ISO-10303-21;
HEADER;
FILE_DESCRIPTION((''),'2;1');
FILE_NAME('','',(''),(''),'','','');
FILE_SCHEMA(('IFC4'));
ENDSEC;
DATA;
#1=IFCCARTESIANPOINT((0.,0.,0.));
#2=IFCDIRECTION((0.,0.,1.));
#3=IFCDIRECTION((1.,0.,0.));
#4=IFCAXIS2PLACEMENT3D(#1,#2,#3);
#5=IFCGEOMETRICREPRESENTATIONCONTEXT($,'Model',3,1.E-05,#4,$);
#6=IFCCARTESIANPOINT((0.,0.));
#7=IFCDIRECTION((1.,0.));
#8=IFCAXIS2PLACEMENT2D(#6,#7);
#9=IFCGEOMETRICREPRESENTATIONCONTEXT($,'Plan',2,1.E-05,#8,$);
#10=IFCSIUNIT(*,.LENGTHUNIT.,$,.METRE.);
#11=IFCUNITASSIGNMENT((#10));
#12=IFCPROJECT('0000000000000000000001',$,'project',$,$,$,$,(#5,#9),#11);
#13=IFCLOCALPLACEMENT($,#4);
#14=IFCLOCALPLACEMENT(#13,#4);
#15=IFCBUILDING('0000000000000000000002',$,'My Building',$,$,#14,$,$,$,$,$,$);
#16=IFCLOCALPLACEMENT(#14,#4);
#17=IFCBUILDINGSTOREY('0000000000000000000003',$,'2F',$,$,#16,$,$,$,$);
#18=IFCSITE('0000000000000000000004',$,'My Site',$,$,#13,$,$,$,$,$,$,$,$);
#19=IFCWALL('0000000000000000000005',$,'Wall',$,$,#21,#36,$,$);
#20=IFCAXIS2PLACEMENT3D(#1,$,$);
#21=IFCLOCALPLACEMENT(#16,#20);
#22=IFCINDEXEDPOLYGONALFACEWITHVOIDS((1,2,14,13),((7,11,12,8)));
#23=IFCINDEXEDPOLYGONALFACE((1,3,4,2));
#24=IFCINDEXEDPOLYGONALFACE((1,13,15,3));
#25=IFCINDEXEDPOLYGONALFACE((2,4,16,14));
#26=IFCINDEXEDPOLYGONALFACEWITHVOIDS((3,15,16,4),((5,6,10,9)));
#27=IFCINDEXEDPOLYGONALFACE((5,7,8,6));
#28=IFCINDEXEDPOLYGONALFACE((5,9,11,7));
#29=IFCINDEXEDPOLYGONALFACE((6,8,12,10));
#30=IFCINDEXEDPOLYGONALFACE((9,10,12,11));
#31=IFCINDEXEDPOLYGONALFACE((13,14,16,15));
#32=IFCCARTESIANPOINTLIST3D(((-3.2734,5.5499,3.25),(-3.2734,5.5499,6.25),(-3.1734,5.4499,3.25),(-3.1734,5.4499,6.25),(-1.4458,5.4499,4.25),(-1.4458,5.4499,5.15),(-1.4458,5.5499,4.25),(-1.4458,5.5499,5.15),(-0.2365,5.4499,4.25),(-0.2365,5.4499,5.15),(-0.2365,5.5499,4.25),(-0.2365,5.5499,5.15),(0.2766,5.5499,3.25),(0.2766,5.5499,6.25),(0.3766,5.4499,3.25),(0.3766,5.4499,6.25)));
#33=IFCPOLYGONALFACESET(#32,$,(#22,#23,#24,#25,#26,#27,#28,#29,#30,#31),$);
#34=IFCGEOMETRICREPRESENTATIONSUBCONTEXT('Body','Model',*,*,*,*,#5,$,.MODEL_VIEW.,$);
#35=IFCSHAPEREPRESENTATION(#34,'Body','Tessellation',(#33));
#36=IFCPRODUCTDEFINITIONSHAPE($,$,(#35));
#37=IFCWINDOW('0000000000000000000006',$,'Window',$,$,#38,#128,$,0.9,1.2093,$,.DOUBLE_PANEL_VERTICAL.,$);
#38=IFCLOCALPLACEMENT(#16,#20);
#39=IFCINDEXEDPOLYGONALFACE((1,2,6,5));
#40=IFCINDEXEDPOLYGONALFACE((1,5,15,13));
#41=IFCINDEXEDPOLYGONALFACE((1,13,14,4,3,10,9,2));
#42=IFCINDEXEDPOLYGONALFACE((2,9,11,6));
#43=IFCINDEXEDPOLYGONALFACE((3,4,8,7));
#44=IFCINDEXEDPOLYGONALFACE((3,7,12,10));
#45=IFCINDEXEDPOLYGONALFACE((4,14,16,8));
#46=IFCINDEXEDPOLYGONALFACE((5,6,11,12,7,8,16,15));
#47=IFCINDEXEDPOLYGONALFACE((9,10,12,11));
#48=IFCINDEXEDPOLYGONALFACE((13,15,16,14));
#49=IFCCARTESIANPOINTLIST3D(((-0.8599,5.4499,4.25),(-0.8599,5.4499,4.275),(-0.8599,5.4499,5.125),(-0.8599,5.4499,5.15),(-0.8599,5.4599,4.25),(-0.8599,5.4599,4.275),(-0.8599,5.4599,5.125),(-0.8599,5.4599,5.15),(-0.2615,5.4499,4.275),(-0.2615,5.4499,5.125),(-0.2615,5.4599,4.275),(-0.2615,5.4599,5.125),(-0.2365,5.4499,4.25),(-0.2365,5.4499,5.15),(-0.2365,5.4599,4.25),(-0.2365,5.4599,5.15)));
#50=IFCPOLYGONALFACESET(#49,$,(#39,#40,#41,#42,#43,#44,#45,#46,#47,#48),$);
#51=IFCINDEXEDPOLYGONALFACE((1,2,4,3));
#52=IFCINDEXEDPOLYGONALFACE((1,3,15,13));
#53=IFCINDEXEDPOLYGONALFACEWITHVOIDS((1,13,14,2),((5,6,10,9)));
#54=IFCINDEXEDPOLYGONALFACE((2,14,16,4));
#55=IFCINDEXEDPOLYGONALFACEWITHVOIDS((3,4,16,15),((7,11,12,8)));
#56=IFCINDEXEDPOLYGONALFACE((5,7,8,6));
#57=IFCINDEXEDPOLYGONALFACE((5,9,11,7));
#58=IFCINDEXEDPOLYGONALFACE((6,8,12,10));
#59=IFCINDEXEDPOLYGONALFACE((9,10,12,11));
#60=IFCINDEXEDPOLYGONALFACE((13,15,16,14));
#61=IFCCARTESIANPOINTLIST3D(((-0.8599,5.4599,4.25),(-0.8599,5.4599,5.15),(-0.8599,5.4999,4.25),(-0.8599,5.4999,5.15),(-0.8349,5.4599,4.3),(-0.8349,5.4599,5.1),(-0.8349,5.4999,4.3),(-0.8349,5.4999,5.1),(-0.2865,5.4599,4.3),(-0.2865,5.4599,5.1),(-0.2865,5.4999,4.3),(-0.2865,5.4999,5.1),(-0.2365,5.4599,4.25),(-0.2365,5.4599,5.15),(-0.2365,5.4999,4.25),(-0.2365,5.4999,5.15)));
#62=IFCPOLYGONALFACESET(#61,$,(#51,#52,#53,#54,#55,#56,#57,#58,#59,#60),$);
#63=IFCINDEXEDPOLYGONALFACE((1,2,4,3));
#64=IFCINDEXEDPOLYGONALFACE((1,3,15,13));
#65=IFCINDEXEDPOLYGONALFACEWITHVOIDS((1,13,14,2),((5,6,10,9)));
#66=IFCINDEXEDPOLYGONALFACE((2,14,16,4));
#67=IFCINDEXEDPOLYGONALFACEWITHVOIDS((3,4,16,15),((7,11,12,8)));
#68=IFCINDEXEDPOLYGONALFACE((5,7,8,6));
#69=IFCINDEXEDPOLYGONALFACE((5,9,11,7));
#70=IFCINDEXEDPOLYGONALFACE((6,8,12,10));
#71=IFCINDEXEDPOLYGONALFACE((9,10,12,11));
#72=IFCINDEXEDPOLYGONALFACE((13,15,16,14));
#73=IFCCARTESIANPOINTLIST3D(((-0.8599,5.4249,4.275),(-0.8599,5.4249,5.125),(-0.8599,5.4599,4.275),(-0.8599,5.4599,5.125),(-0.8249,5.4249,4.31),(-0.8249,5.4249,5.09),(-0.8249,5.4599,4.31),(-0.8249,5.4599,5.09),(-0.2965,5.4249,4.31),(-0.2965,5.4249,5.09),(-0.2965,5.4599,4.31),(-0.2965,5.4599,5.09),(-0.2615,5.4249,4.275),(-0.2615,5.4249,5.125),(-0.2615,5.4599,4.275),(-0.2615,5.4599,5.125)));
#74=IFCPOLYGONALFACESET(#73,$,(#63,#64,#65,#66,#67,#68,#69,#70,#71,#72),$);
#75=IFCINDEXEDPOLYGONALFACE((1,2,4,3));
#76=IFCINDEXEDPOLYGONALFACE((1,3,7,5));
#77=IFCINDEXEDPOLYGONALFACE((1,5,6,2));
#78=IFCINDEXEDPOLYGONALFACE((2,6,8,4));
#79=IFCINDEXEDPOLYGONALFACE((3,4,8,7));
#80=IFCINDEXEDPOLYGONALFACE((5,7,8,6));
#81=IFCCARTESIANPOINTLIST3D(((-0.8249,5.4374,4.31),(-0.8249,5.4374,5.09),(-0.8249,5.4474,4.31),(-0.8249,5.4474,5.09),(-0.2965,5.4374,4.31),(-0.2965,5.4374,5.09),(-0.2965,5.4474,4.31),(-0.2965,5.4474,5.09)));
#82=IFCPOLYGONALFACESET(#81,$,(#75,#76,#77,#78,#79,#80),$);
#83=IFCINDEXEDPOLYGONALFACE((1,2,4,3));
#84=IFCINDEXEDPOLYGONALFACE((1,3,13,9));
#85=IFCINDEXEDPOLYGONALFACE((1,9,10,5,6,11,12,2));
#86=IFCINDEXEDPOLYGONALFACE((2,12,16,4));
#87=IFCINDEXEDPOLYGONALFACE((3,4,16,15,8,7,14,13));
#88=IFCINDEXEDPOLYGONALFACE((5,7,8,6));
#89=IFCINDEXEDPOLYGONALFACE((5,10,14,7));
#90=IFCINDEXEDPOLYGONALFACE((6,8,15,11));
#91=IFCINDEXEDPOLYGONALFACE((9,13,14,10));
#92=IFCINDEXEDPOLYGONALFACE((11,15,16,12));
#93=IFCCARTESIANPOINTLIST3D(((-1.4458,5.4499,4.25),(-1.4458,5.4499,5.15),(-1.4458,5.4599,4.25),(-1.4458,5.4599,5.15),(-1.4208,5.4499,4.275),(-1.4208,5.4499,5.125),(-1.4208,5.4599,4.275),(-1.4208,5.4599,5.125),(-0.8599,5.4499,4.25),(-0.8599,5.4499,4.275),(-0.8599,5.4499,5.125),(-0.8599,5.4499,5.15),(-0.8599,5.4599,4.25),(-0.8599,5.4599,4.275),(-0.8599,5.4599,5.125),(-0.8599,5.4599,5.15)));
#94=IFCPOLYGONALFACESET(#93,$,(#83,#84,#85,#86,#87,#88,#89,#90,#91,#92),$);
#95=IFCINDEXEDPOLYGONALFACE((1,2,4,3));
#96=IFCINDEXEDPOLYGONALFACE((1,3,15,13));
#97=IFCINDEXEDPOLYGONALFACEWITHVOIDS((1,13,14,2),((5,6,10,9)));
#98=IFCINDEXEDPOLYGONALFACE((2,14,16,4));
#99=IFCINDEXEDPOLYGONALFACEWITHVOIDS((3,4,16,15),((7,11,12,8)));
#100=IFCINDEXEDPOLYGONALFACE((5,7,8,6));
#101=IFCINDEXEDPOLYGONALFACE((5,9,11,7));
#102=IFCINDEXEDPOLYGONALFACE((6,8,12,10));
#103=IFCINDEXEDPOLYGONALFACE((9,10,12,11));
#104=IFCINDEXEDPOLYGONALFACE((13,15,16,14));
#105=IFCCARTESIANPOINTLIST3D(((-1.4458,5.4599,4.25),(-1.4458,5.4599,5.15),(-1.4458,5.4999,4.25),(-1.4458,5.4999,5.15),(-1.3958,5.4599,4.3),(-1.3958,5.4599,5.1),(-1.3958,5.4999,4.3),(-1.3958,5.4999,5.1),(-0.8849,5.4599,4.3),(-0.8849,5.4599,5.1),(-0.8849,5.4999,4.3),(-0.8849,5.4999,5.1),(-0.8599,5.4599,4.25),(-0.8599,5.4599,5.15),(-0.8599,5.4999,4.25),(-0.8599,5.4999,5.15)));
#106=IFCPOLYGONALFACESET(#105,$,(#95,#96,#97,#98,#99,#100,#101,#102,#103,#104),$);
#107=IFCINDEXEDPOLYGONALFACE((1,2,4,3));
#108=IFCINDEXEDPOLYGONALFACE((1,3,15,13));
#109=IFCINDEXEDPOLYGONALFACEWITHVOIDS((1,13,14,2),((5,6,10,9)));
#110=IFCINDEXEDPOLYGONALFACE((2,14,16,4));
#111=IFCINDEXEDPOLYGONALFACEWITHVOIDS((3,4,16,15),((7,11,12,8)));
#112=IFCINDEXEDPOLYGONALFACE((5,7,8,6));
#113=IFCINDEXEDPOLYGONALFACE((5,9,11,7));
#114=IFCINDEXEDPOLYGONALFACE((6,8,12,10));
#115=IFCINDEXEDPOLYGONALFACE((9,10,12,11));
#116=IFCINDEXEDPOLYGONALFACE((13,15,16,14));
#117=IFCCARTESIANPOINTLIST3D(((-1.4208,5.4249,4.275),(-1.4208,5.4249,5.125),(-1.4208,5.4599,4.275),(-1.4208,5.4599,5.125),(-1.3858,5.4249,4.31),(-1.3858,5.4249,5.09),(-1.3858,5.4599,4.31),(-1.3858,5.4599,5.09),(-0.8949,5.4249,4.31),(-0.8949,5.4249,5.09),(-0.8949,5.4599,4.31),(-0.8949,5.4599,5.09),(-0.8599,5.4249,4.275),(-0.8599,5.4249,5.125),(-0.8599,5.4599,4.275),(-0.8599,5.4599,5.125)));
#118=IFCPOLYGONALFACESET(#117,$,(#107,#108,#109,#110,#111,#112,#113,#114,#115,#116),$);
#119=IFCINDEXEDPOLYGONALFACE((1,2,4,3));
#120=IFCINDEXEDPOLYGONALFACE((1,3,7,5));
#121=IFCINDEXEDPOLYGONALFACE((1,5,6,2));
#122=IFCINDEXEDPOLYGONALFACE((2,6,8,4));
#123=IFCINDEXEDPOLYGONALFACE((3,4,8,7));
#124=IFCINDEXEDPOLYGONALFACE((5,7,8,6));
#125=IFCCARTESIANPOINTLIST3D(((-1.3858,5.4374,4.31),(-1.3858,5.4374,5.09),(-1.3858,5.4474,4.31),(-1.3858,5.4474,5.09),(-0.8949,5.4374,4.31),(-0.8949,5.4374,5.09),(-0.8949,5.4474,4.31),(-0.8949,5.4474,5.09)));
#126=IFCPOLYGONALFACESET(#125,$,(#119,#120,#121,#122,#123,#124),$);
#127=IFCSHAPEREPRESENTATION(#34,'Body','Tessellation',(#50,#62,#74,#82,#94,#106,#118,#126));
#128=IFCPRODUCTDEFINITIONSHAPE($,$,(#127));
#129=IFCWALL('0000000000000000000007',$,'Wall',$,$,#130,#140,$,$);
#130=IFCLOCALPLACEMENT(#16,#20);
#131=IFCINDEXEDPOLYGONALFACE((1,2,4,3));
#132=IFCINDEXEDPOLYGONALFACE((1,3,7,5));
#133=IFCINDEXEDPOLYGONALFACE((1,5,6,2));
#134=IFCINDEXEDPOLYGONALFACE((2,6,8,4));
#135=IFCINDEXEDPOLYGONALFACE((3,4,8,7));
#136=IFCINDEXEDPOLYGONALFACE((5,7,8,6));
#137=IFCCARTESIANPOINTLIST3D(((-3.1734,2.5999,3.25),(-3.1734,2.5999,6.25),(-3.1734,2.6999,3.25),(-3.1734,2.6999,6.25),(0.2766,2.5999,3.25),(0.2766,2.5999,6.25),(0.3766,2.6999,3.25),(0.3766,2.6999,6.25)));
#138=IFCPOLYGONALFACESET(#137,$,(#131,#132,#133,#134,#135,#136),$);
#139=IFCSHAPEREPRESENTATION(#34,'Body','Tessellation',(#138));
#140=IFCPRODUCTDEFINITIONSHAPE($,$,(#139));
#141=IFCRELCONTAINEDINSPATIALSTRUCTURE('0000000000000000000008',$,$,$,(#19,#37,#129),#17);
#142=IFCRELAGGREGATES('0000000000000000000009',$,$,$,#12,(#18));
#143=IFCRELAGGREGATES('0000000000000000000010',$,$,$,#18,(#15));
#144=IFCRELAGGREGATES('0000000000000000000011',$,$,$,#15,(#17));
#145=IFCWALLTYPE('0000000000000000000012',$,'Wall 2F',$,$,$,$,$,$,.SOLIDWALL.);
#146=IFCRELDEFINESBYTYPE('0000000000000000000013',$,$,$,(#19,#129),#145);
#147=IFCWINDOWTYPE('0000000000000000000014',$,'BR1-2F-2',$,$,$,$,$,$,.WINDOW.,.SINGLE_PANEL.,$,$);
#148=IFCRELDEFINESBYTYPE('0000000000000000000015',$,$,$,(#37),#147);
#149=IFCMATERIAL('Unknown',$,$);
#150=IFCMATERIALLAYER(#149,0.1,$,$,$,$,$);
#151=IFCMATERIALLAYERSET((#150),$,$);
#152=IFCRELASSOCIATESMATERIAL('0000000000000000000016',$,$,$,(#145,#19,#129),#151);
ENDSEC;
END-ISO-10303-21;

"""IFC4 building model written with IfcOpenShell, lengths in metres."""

from ifc_helpers import new_model, entity, si_unit, frame, origin_with_axes, origin_2d_with_axis, place, context, subcontext, project, spatial, line, indexed_curve, outline, extrude, shape, source, transform, mapped, material, layer, layer_set, layer_usage, type_object, type_shapes, element, fill, save


model = new_model("IFC4")

# Units and contexts
model_context = context("Model", 3, precision=1e-05, world=origin_with_axes())
plan_context = context("Plan", 2, precision=1e-05, world=origin_2d_with_axis())
body_context_1 = subcontext(model_context, "Body", "Model", "MODEL_VIEW")
body_context_2 = subcontext(plan_context, "Body", "Plan", "PLAN_VIEW")
ifc_project = project(units=[si_unit("LENGTHUNIT", "METRE")], contexts=[model_context, plan_context])

# Site, building, storey
site_placement = place(None, origin_with_axes())
site = spatial("IfcSite", under=ifc_project, at=site_placement, Name="My Site")
building_placement = place(site_placement, origin_with_axes())
building = spatial("IfcBuilding", under=site, at=building_placement, Name="My Building")
storey_placement = place(building_placement, origin_with_axes())
storey = spatial("IfcBuildingStorey", under=building, at=storey_placement, Name="2F")

# Shared definitions
ifc_material = material(Name="Unknown")

# Shared definitions
ifc_layer = layer(ifc_material, 0.1)
ifc_layer_set = layer_set([ifc_layer])
wall_type = type_object("IfcWallType", Name="Wall 2F", PredefinedType="SOLIDWALL", material=ifc_layer_set)

# Wall, opening, window
ifc_layer_usage_1 = layer_usage(ifc_layer_set, "AXIS2", "POSITIVE", 0.0)
wall_1_placement = place(storey_placement, frame((0.2766, 5.5499, 3.25), z_axis=(0.0, 0.0, 1.0), x_axis=(-1.0, 0.0, 0.0)))
wall_1 = element("IfcWall", 1, at=wall_1_placement, inside=storey, type_object=wall_type, material=ifc_layer_usage_1, Name="Wall", context=body_context_1, shape_type="SweptSolid", body=[
    extrude(outline(indexed_curve([(0.0, 0.0), (-0.1, 0.1), (3.45, 0.1), (3.55, 0.0)], segments=[line(1, 2, 3, 4, 1)])), origin_with_axes(), (0.0, 0.0, 1.0), 3.0),
])
shared_shape_1 = source(origin_with_axes(), body_context_1, "Body", "SweptSolid", [
    extrude(outline(indexed_curve([(0.0, 0.0), (1.2093, 0.0), (1.2093, 0.9), (0.0, 0.9)], segments=[line(1, 2, 3, 4, 1)])), frame((0.0, -0.6, 0.0), z_axis=(0.0, -1.0, 0.0), x_axis=(1.0, 0.0, 0.0)), (0.0, 0.0, -1.0), 1.2),
])
opening_1_placement = place(wall_1_placement, frame((0.5131, 0.0, 1.0), z_axis=(0.0, 0.0, 1.0), x_axis=(1.0, 0.0, 0.0)))
opening_1 = element("IfcOpeningElement", 2, at=opening_1_placement, cuts=wall_1, PredefinedType="OPENING", context=body_context_1, shape_type="MappedRepresentation", body=[
    mapped(shared_shape_1, transform((0.0, 0.0, 0.0), x_axis=(1.0, 0.0, 0.0), y_axis=(0.0, 1.0, 0.0), z_axis=(0.0, 0.0, 1.0), scale=1.0)),
])
window_type_1 = type_object("IfcWindowType", Name="BR1-2F-2", PartitioningType="SINGLE_PANEL", PredefinedType="WINDOW")
shared_shape_2 = source(origin_with_axes(), body_context_1, "Body", "SweptSolid", [
    extrude(outline(indexed_curve([(0.6234, 0.0), (0.0, 0.0), (0.0, 0.9), (0.6234, 0.9), (0.6234, 0.875), (0.025, 0.875), (0.025, 0.025), (0.6234, 0.025)], segments=[line(1, 2, 3, 4, 5, 6, 7, 8, 1)])), frame((0.0, 0.09, 0.0), z_axis=(0.0, -1.0, 0.0), x_axis=(1.0, 0.0, 0.0)), (0.0, 0.0, -1.0), 0.01),
    extrude(outline(indexed_curve([(0.0, 0.0), (0.6234, 0.0), (0.6234, 0.9), (0.0, 0.9)], segments=[line(1, 2, 3, 4, 1)]), holes=[indexed_curve([(0.05, 0.05), (0.5984, 0.05), (0.5984, 0.85), (0.05, 0.85)], segments=[line(1, 2, 3, 4, 1)])]), frame((0.0, 0.05, 0.0), z_axis=(0.0, -1.0, 0.0), x_axis=(1.0, 0.0, 0.0)), (0.0, 0.0, -1.0), 0.04),
    extrude(outline(indexed_curve([(0.0, 0.0), (0.5984, 0.0), (0.5984, 0.85), (0.0, 0.85)], segments=[line(1, 2, 3, 4, 1)]), holes=[indexed_curve([(0.035, 0.035), (0.5634, 0.035), (0.5634, 0.815), (0.035, 0.815)], segments=[line(1, 2, 3, 4, 1)])]), frame((0.025, 0.09, 0.025), z_axis=(0.0, -1.0, 0.0), x_axis=(1.0, 0.0, 0.0)), (0.0, 0.0, -1.0), 0.035),
    extrude(outline(indexed_curve([(0.035, 0.035), (0.5634, 0.035), (0.5634, 0.815), (0.035, 0.815)], segments=[line(1, 2, 3, 4, 1)])), frame((0.025, 0.1025, 0.025), z_axis=(0.0, -1.0, 0.0), x_axis=(1.0, 0.0, 0.0)), (0.0, 0.0, -1.0), 0.01),
    extrude(outline(indexed_curve([(0.0, 0.9), (0.5859, 0.9), (0.5859, 0.0), (0.0, 0.0), (0.0, 0.025), (0.5609, 0.025), (0.5609, 0.875), (0.0, 0.875)], segments=[line(1, 2, 3, 4, 5, 6, 7, 8, 1)])), frame((0.6234, 0.09, 0.0), z_axis=(0.0, -1.0, 0.0), x_axis=(1.0, 0.0, 0.0)), (0.0, 0.0, -1.0), 0.01),
    extrude(outline(indexed_curve([(0.0, 0.0), (0.5859, 0.0), (0.5859, 0.9), (0.0, 0.9)], segments=[line(1, 2, 3, 4, 1)]), holes=[indexed_curve([(0.025, 0.05), (0.5359, 0.05), (0.5359, 0.85), (0.025, 0.85)], segments=[line(1, 2, 3, 4, 1)])]), frame((0.6234, 0.05, 0.0), z_axis=(0.0, -1.0, 0.0), x_axis=(1.0, 0.0, 0.0)), (0.0, 0.0, -1.0), 0.04),
    extrude(outline(indexed_curve([(0.0, 0.0), (0.5609, 0.0), (0.5609, 0.85), (0.0, 0.85)], segments=[line(1, 2, 3, 4, 1)]), holes=[indexed_curve([(0.035, 0.035), (0.5259, 0.035), (0.5259, 0.815), (0.035, 0.815)], segments=[line(1, 2, 3, 4, 1)])]), frame((0.6234, 0.09, 0.025), z_axis=(0.0, -1.0, 0.0), x_axis=(1.0, 0.0, 0.0)), (0.0, 0.0, -1.0), 0.035),
    extrude(outline(indexed_curve([(0.035, 0.035), (0.5259, 0.035), (0.5259, 0.815), (0.035, 0.815)], segments=[line(1, 2, 3, 4, 1)])), frame((0.6234, 0.1025, 0.025), z_axis=(0.0, -1.0, 0.0), x_axis=(1.0, 0.0, 0.0)), (0.0, 0.0, -1.0), 0.01),
])
shared_shape_3 = source(origin_with_axes(), body_context_2, "Body", "Curve2D", [
    entity("IfcIndexedPolyCurve", entity("IfcCartesianPointList2D", [[0.05, 0.05], [0.5984, 0.05]])),
    entity("IfcIndexedPolyCurve", entity("IfcCartesianPointList2D", [[0.0, 0.1], [0.025, 0.1], [0.025, 0.09], [0.05, 0.09], [0.05, 0.05], [0.0, 0.05]]), [entity("IfcLineIndex", [1, 2, 3, 4, 5, 6, 1])]),
    entity("IfcIndexedPolyCurve", entity("IfcCartesianPointList2D", [[0.6234, 0.1], [0.6234, 0.1], [0.6234, 0.09], [0.5984, 0.09], [0.5984, 0.05], [0.6234, 0.05]])),
    entity("IfcIndexedPolyCurve", entity("IfcCartesianPointList2D", [[0.025, 0.09], [0.06, 0.09], [0.06, 0.125], [0.025, 0.125]]), [entity("IfcLineIndex", [1, 2, 3, 4, 1])]),
    entity("IfcIndexedPolyCurve", entity("IfcCartesianPointList2D", [[0.6234, 0.09], [0.5884, 0.09], [0.5884, 0.125], [0.6234, 0.125]]), [entity("IfcLineIndex", [1, 2, 3, 4, 1])]),
    entity("IfcIndexedPolyCurve", entity("IfcCartesianPointList2D", [[0.06, 0.09], [0.5884, 0.09]])),
    entity("IfcIndexedPolyCurve", entity("IfcCartesianPointList2D", [[0.06, 0.125], [0.5884, 0.125]])),
    entity("IfcIndexedPolyCurve", entity("IfcCartesianPointList2D", [[0.06, 0.1075], [0.5884, 0.1075]])),
    entity("IfcIndexedPolyCurve", entity("IfcCartesianPointList2D", [[0.6484, 0.05], [1.1593, 0.05]])),
    entity("IfcIndexedPolyCurve", entity("IfcCartesianPointList2D", [[0.6234, 0.1], [0.6234, 0.1], [0.6234, 0.09], [0.6484, 0.09], [0.6484, 0.05], [0.6234, 0.05]])),
    entity("IfcIndexedPolyCurve", entity("IfcCartesianPointList2D", [[1.2093, 0.1], [1.1843, 0.1], [1.1843, 0.09], [1.1593, 0.09], [1.1593, 0.05], [1.2093, 0.05]]), [entity("IfcLineIndex", [1, 2, 3, 4, 5, 6, 1])]),
    entity("IfcIndexedPolyCurve", entity("IfcCartesianPointList2D", [[0.6234, 0.09], [0.6584, 0.09], [0.6584, 0.125], [0.6234, 0.125]]), [entity("IfcLineIndex", [1, 2, 3, 4, 1])]),
    entity("IfcIndexedPolyCurve", entity("IfcCartesianPointList2D", [[1.1843, 0.09], [1.1493, 0.09], [1.1493, 0.125], [1.1843, 0.125]]), [entity("IfcLineIndex", [1, 2, 3, 4, 1])]),
    entity("IfcIndexedPolyCurve", entity("IfcCartesianPointList2D", [[0.6584, 0.09], [1.1493, 0.09]])),
    entity("IfcIndexedPolyCurve", entity("IfcCartesianPointList2D", [[0.6584, 0.125], [1.1493, 0.125]])),
    entity("IfcIndexedPolyCurve", entity("IfcCartesianPointList2D", [[0.6584, 0.1075], [1.1493, 0.1075]])),
])
type_shapes(window_type_1, [shared_shape_2, shared_shape_3])
window_1_placement = place(opening_1_placement, frame((0.0, 0.0, 0.0), z_axis=(0.0, 0.0, 1.0), x_axis=(1.0, 0.0, 0.0)))
window_1 = element("IfcWindow", 3, at=window_1_placement, inside=storey, type_object=window_type_1, Name="Window", OverallHeight=0.9, OverallWidth=1.2093, PartitioningType="DOUBLE_PANEL_VERTICAL", shapes=[
    shape(body_context_1, "Body", "MappedRepresentation", [mapped(shared_shape_2, transform((0.0, 0.0, 0.0), x_axis=(1.0, 0.0, 0.0), y_axis=(0.0, 1.0, 0.0), z_axis=(0.0, 0.0, 1.0), scale=1.0))]),
    shape(body_context_2, "Body", "MappedRepresentation", [mapped(shared_shape_3, transform((0.0, 0.0, 0.0), x_axis=(1.0, 0.0, 0.0), y_axis=(0.0, 1.0, 0.0), z_axis=(0.0, 0.0, 1.0), scale=1.0))]),
])
fill(opening_1, window_1)

# Wall
ifc_layer_usage_2 = layer_usage(ifc_layer_set, "AXIS2", "POSITIVE", 0.0)
wall_2_placement = place(storey_placement, frame((0.3766, 2.6999, 3.25), z_axis=(0.0, 0.0, 1.0), x_axis=(-1.0, 0.0, 0.0)))
element("IfcWall", 4, at=wall_2_placement, inside=storey, type_object=wall_type, material=ifc_layer_usage_2, Name="Wall", context=body_context_1, shape_type="SweptSolid", body=[
    extrude(outline(indexed_curve([(0.0, 0.0), (0.1, 0.1), (3.55, 0.1), (3.55, 0.0)], segments=[line(1, 2, 3, 4, 1)])), origin_with_axes(), (0.0, 0.0, 1.0), 3.0),
])

save(model, "model.ifc")
